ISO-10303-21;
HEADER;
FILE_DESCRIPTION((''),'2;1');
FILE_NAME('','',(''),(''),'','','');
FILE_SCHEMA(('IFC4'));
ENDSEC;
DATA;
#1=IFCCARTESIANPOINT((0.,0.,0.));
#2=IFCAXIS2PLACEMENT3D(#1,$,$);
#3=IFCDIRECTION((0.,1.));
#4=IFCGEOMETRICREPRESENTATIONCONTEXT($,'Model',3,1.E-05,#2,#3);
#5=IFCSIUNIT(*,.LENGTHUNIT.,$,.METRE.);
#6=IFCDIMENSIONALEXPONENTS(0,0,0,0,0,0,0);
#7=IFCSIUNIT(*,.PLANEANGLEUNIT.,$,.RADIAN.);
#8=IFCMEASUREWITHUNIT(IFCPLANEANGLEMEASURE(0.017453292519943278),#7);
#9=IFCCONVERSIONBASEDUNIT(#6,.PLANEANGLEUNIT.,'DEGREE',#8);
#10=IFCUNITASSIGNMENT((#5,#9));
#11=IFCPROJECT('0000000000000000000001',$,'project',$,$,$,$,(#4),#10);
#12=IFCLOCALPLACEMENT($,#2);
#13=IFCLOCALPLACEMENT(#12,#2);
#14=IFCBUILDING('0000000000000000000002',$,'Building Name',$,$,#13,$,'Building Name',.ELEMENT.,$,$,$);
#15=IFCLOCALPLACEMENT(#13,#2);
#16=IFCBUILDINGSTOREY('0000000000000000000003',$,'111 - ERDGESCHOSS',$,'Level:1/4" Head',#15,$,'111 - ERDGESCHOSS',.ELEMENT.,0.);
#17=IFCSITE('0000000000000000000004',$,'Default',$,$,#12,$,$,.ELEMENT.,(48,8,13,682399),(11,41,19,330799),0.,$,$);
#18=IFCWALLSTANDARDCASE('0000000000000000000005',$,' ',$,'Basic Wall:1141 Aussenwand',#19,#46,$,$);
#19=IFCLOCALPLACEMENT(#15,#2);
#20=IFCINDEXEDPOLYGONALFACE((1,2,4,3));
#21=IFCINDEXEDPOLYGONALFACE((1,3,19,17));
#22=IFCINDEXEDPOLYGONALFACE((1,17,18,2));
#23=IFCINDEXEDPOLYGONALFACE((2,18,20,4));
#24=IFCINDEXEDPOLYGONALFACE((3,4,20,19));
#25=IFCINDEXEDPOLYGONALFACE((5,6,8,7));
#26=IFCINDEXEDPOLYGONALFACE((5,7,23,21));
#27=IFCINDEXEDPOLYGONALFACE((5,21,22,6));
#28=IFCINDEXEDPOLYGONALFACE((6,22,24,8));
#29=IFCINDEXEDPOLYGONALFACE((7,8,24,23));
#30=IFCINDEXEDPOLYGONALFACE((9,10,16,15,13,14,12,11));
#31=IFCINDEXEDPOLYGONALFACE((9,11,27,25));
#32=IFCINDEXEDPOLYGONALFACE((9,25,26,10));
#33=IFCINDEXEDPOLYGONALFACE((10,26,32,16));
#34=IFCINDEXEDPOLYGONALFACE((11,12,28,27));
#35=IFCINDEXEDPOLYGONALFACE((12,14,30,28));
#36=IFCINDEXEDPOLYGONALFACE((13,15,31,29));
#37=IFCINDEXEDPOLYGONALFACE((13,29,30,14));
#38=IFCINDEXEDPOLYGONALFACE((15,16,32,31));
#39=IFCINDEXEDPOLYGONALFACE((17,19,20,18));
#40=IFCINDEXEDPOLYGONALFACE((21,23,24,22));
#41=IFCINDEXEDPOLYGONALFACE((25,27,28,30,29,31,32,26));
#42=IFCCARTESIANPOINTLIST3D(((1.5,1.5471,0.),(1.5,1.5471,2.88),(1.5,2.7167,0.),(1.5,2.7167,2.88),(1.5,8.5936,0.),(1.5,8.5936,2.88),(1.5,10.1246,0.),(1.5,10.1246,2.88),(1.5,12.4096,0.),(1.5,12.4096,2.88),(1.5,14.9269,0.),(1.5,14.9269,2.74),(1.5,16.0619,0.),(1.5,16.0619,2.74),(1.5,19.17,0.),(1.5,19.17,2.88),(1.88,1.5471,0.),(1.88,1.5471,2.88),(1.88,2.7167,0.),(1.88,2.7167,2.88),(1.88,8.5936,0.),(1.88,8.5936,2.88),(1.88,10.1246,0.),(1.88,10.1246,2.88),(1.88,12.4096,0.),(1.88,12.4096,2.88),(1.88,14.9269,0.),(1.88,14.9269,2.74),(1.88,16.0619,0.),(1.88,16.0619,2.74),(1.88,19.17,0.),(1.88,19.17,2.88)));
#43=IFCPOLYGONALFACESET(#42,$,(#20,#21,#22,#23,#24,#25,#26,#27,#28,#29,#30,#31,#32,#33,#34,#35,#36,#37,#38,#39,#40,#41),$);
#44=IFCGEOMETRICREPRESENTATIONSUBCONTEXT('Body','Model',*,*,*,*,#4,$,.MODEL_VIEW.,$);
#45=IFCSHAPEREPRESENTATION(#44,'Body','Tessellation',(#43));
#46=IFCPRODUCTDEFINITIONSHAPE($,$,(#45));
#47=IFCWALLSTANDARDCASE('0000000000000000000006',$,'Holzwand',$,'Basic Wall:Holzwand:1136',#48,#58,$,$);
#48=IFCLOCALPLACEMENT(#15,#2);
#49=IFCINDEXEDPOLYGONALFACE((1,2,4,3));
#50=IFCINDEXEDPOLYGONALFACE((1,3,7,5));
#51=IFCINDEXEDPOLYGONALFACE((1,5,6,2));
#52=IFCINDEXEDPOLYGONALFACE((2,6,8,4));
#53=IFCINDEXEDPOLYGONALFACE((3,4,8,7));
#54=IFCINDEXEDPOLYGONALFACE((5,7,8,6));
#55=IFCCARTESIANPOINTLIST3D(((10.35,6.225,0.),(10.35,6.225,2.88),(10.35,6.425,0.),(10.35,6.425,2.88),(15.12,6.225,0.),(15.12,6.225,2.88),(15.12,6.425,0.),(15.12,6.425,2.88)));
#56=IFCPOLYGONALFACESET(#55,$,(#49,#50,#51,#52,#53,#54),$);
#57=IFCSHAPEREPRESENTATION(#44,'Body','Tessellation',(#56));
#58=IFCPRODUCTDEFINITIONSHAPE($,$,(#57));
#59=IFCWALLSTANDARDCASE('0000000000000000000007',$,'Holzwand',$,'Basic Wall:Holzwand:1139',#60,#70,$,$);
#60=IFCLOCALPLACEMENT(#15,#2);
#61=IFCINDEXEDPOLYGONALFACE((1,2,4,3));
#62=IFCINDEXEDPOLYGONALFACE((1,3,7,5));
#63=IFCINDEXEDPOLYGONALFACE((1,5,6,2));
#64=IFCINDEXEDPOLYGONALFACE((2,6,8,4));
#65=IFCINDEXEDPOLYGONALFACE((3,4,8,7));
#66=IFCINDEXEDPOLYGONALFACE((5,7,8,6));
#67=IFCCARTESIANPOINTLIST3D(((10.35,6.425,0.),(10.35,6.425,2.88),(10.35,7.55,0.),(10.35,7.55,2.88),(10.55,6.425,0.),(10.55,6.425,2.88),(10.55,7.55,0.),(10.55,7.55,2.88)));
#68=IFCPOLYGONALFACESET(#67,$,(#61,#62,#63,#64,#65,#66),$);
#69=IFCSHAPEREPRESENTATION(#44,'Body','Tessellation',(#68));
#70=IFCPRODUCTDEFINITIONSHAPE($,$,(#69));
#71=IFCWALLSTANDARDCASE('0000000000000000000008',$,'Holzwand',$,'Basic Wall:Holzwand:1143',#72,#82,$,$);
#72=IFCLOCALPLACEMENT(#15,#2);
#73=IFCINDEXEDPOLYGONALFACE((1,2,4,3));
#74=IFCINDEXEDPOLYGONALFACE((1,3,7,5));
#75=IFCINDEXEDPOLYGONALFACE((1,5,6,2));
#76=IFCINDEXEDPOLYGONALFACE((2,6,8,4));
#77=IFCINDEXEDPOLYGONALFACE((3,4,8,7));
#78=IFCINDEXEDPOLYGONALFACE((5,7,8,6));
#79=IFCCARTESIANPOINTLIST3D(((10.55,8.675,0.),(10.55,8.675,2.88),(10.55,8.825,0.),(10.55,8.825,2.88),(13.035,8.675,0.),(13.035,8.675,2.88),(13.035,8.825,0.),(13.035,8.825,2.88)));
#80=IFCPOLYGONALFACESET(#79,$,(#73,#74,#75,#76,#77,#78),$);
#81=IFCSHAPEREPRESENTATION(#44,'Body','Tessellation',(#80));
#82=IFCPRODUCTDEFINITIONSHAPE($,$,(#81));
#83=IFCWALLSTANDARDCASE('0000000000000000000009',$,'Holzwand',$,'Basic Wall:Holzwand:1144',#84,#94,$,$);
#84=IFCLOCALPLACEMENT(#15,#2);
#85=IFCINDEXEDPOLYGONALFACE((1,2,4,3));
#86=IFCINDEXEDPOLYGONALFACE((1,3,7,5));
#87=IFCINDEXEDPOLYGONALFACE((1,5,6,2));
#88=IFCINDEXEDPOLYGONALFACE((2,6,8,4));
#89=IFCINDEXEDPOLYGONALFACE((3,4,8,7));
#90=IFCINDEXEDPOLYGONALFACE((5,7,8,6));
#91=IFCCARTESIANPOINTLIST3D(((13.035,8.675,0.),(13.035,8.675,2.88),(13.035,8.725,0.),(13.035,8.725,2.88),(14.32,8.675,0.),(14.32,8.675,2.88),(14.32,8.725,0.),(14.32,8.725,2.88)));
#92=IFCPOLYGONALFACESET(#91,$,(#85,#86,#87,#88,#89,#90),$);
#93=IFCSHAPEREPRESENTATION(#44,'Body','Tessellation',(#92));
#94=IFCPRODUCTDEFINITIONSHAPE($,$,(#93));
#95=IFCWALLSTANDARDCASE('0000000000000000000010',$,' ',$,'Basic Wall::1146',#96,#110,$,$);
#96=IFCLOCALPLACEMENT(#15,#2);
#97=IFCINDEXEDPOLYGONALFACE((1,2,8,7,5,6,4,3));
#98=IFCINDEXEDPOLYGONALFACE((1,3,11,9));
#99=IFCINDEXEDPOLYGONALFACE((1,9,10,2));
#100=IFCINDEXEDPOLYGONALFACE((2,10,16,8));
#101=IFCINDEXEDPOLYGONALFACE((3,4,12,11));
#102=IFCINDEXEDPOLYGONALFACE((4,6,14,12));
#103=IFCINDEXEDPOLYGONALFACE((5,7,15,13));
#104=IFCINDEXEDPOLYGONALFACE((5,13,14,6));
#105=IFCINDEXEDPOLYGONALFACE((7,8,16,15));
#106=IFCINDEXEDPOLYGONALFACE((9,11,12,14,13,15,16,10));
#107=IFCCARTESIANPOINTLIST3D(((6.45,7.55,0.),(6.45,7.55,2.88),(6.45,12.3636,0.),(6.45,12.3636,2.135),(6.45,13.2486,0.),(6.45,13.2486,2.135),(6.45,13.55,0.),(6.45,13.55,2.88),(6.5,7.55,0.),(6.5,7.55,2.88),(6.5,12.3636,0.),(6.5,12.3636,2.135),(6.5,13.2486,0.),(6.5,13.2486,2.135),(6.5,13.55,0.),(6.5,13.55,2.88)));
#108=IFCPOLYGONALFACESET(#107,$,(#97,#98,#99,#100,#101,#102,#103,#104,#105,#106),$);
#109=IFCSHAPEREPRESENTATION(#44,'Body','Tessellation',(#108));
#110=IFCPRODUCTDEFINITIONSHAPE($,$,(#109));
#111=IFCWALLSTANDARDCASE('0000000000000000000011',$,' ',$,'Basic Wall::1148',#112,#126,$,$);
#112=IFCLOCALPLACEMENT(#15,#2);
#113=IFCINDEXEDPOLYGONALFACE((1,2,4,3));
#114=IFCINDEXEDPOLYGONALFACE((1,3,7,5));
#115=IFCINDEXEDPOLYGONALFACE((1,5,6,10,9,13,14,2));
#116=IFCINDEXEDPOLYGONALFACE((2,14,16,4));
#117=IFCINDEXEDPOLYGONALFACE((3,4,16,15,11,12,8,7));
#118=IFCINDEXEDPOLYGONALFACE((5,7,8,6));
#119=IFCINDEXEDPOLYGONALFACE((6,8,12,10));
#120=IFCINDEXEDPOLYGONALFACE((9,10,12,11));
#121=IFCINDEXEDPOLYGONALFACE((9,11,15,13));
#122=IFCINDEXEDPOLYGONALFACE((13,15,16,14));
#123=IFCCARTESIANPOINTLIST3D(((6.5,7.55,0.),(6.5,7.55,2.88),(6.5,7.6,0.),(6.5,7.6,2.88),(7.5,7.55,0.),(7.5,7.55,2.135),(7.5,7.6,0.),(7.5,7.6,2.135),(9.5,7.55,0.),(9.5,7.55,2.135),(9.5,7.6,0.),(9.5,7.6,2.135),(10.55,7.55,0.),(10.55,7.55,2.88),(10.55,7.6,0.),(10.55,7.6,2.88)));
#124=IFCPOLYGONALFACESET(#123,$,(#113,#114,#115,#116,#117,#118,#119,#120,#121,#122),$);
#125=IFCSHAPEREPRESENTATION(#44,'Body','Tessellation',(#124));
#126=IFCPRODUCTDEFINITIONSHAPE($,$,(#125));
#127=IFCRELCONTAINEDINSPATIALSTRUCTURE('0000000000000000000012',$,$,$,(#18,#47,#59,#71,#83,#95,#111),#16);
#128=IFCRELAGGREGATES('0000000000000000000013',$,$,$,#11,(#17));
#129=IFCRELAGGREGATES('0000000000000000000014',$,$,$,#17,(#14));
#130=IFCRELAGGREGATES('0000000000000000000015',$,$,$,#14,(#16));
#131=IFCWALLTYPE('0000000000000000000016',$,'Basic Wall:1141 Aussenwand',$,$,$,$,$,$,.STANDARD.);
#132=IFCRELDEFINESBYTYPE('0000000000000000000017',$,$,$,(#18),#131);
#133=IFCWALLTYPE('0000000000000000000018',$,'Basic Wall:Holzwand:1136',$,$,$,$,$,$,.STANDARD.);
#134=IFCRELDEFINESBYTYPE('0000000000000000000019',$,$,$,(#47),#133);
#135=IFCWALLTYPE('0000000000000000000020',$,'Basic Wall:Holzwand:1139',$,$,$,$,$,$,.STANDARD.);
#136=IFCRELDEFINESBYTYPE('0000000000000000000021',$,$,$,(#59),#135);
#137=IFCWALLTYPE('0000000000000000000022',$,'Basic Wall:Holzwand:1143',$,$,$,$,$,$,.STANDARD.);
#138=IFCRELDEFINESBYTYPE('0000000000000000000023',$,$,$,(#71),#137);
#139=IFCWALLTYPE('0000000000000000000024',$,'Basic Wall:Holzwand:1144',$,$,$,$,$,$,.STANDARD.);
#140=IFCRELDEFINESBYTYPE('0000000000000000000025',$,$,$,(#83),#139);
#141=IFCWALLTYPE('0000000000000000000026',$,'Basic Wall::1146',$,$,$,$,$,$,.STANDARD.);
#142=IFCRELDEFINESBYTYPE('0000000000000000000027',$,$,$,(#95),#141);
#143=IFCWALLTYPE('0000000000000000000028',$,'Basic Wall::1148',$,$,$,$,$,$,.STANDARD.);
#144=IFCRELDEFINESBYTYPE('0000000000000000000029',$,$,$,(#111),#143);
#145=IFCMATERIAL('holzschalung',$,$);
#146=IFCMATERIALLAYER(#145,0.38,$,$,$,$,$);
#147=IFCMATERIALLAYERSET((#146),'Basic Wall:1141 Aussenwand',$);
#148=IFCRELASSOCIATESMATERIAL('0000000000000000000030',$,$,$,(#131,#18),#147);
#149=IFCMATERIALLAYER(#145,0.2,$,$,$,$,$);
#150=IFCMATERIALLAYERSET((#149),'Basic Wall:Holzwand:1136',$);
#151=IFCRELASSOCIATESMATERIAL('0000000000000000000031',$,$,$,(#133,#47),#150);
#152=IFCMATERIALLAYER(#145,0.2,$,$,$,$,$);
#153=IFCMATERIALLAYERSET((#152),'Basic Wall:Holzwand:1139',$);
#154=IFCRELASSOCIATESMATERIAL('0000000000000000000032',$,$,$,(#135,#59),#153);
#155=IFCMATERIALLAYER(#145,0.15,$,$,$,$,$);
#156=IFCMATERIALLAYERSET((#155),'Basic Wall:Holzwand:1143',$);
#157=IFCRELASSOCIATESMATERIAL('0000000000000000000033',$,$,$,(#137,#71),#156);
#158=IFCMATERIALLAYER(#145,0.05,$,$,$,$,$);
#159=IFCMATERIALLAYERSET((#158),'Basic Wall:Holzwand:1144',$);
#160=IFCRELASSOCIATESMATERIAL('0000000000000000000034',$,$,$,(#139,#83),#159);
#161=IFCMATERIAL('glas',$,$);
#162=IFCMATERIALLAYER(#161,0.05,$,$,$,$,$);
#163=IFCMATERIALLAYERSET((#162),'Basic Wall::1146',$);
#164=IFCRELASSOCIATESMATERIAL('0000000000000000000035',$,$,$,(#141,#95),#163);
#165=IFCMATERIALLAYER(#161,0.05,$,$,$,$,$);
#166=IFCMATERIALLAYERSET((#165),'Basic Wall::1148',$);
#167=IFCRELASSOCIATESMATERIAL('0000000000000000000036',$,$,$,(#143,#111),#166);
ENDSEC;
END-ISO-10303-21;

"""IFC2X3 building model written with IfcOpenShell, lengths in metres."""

from ifc_helpers import new_model, entity, si_unit, converted_unit, direction, frame, frame_2d, origin, place, context, subcontext, project, spatial, rectangle, extrude, material, layer, layer_set, layer_usage, type_object, element, save


model = new_model("IFC2X3")

# Units and contexts
model_context = context("Model", 3, precision=1e-05, world=origin(), true_north=direction((0.0, 1.0)))
body_context = subcontext(model_context, "Body", "Model", "MODEL_VIEW")
ifc_project = project(units=[si_unit("LENGTHUNIT", "METRE"), converted_unit("PLANEANGLEUNIT", "DEGREE", entity("IfcPlaneAngleMeasure", 0.017453292519943278), si_unit("PLANEANGLEUNIT", "RADIAN"), dimensions=[0, 0, 0, 0, 0, 0, 0])], contexts=[model_context])

# Site, building, storey
site_placement = place(None, origin())
site = spatial("IfcSite", under=ifc_project, at=site_placement, Name="Default", CompositionType="ELEMENT", RefLatitude=(48, 8, 13, 682399), RefLongitude=(11, 41, 19, 330799), RefElevation=0.0)
building_placement = place(site_placement, origin())
building = spatial("IfcBuilding", under=site, at=building_placement, Name="Building Name", LongName="Building Name", CompositionType="ELEMENT")
storey_placement = place(building_placement, origin())
storey = spatial("IfcBuildingStorey", under=building, at=storey_placement, Name="111 - ERDGESCHOSS", ObjectType="Level:1/4\" Head", LongName="111 - ERDGESCHOSS", CompositionType="ELEMENT", Elevation=0.0)

# Wall, openings
ifc_material_1 = material(Name="holzschalung")
ifc_layer_1 = layer(ifc_material_1, 0.38)
ifc_layer_set_1 = layer_set([ifc_layer_1], Name="Basic Wall:1141 Aussenwand")
ifc_layer_usage_1 = layer_usage(ifc_layer_set_1, "AXIS2", "NEGATIVE", 0.19)
wall_type_1 = type_object("IfcWallType", Name="Basic Wall:1141 Aussenwand", PredefinedType="STANDARD", material=ifc_layer_set_1)
wall_1_placement = place(storey_placement, frame((1.69, 1.5471, 0.0), z_axis=(0.0, 0.0, 1.0), x_axis=(0.0, 1.0, 0.0)))
wall_1 = element("IfcWallStandardCase", 1, at=wall_1_placement, inside=storey, type_object=wall_type_1, material=ifc_layer_usage_1, Name=" ", ObjectType="Basic Wall:1141 Aussenwand", context=body_context, shape_type="SweptSolid", body=[
    extrude(rectangle(XDim=17.6229, YDim=0.38, at=frame_2d((8.8114, 0.0), x_axis=(-1.0, 0.0))), origin(), (0.0, 0.0, 1.0), 2.88),
])
opening_1_placement = place(wall_1_placement, origin())
element("IfcOpeningElement", 2, at=opening_1_placement, cuts=wall_1, ObjectType="Opening", context=body_context, shape_type="SweptSolid", body=[
    extrude(rectangle(XDim=2.88, YDim=1.135, at=frame_2d((0.0, 0.0), x_axis=(0.0, 1.0))), frame((9.145, -0.19, 1.44), z_axis=(0.0, 1.0, 0.0), x_axis=(-1.0, 0.0, 0.0)), (0.0, 0.0, 1.0), 0.38),
])
opening_2_placement = place(wall_1_placement, origin())
element("IfcOpeningElement", 3, at=opening_2_placement, cuts=wall_1, ObjectType="Opening", context=body_context, shape_type="SweptSolid", body=[
    extrude(rectangle(XDim=2.88, YDim=1.135, at=frame_2d((0.0, 0.0), x_axis=(0.0, 1.0))), frame((6.4789, -0.19, 1.44), z_axis=(0.0, 1.0, 0.0), x_axis=(-1.0, 0.0, 0.0)), (0.0, 0.0, 1.0), 0.38),
])
opening_3_placement = place(wall_1_placement, origin())
element("IfcOpeningElement", 4, at=opening_3_placement, cuts=wall_1, ObjectType="Opening", context=body_context, shape_type="SweptSolid", body=[
    extrude(rectangle(XDim=2.88, YDim=1.135, at=frame_2d((0.0, 0.0), x_axis=(0.0, 1.0))), frame((1.7371, -0.19, 1.44), z_axis=(0.0, 1.0, 0.0), x_axis=(-1.0, 0.0, 0.0)), (0.0, 0.0, 1.0), 0.38),
])
opening_4_placement = place(wall_1_placement, origin())
element("IfcOpeningElement", 5, at=opening_4_placement, cuts=wall_1, ObjectType="Opening", context=body_context, shape_type="SweptSolid", body=[
    extrude(rectangle(XDim=2.88, YDim=1.15, at=frame_2d((0.0, 0.0), x_axis=(0.0, 1.0))), frame((10.2875, -0.19, 1.44), z_axis=(0.0, 1.0, 0.0), x_axis=(-1.0, 0.0, 0.0)), (0.0, 0.0, 1.0), 0.38),
])
opening_5_placement = place(wall_1_placement, origin())
element("IfcOpeningElement", 6, at=opening_5_placement, cuts=wall_1, ObjectType="Opening", context=body_context, shape_type="SweptSolid", body=[
    extrude(rectangle(XDim=2.74, YDim=1.135, at=frame_2d((0.0, 0.0), x_axis=(0.0, 1.0))), frame((13.9473, -0.19, 1.37), z_axis=(0.0, 1.0, 0.0), x_axis=(-1.0, 0.0, 0.0)), (0.0, 0.0, 1.0), 0.38),
])
opening_6_placement = place(wall_1_placement, origin())
element("IfcOpeningElement", 7, at=opening_6_placement, cuts=wall_1, ObjectType="Opening", context=body_context, shape_type="SweptSolid", body=[
    extrude(rectangle(XDim=2.88, YDim=3.608, at=frame_2d((0.0, 0.0), x_axis=(0.0, 1.0))), frame((4.1074, -0.19, 1.44), z_axis=(0.0, 1.0, 0.0), x_axis=(-1.0, 0.0, 0.0)), (0.0, 0.0, 1.0), 0.38),
])

# Walls
ifc_layer_2 = layer(ifc_material_1, 0.2)
ifc_layer_set_2 = layer_set([ifc_layer_2], Name="Basic Wall:Holzwand:1136")
ifc_layer_usage_2 = layer_usage(ifc_layer_set_2, "AXIS2", "NEGATIVE", 0.1)
wall_type_2 = type_object("IfcWallType", Name="Basic Wall:Holzwand:1136", PredefinedType="STANDARD", material=ifc_layer_set_2)
wall_2_placement = place(storey_placement, frame((15.12, 6.325, 0.0), z_axis=(0.0, 0.0, 1.0), x_axis=(-1.0, 0.0, 0.0)))
element("IfcWallStandardCase", 8, at=wall_2_placement, inside=storey, type_object=wall_type_2, material=ifc_layer_usage_2, Name="Holzwand", ObjectType="Basic Wall:Holzwand:1136", context=body_context, shape_type="SweptSolid", body=[
    extrude(rectangle(XDim=4.77, YDim=0.2, at=frame_2d((2.385, 0.0), x_axis=(-1.0, 0.0))), origin(), (0.0, 0.0, 1.0), 2.88),
])
ifc_layer_3 = layer(ifc_material_1, 0.2)
ifc_layer_set_3 = layer_set([ifc_layer_3], Name="Basic Wall:Holzwand:1139")
ifc_layer_usage_3 = layer_usage(ifc_layer_set_3, "AXIS2", "NEGATIVE", 0.1)
wall_type_3 = type_object("IfcWallType", Name="Basic Wall:Holzwand:1139", PredefinedType="STANDARD", material=ifc_layer_set_3)
wall_3_placement = place(storey_placement, frame((10.45, 7.55, 0.0), z_axis=(0.0, 0.0, 1.0), x_axis=(0.0, -1.0, 0.0)))
element("IfcWallStandardCase", 9, at=wall_3_placement, inside=storey, type_object=wall_type_3, material=ifc_layer_usage_3, Name="Holzwand", ObjectType="Basic Wall:Holzwand:1139", context=body_context, shape_type="SweptSolid", body=[
    extrude(rectangle(XDim=1.125, YDim=0.2, at=frame_2d((0.5625, 0.0), x_axis=(-1.0, 0.0))), origin(), (0.0, 0.0, 1.0), 2.88),
])
ifc_layer_4 = layer(ifc_material_1, 0.15)
ifc_layer_set_4 = layer_set([ifc_layer_4], Name="Basic Wall:Holzwand:1143")
ifc_layer_usage_4 = layer_usage(ifc_layer_set_4, "AXIS2", "NEGATIVE", 0.075)
wall_type_4 = type_object("IfcWallType", Name="Basic Wall:Holzwand:1143", PredefinedType="STANDARD", material=ifc_layer_set_4)
wall_4_placement = place(storey_placement, frame((13.035, 8.75, 0.0), z_axis=(0.0, 0.0, 1.0), x_axis=(-1.0, 0.0, 0.0)))
element("IfcWallStandardCase", 10, at=wall_4_placement, inside=storey, type_object=wall_type_4, material=ifc_layer_usage_4, Name="Holzwand", ObjectType="Basic Wall:Holzwand:1143", context=body_context, shape_type="SweptSolid", body=[
    extrude(rectangle(XDim=2.485, YDim=0.15, at=frame_2d((1.2425, 0.0), x_axis=(-1.0, 0.0))), origin(), (0.0, 0.0, 1.0), 2.88),
])
ifc_layer_5 = layer(ifc_material_1, 0.05)
ifc_layer_set_5 = layer_set([ifc_layer_5], Name="Basic Wall:Holzwand:1144")
ifc_layer_usage_5 = layer_usage(ifc_layer_set_5, "AXIS2", "NEGATIVE", 0.025)
wall_type_5 = type_object("IfcWallType", Name="Basic Wall:Holzwand:1144", PredefinedType="STANDARD", material=ifc_layer_set_5)
wall_5_placement = place(storey_placement, frame((13.035, 8.7, 0.0)))
element("IfcWallStandardCase", 11, at=wall_5_placement, inside=storey, type_object=wall_type_5, material=ifc_layer_usage_5, Name="Holzwand", ObjectType="Basic Wall:Holzwand:1144", context=body_context, shape_type="SweptSolid", body=[
    extrude(rectangle(XDim=1.285, YDim=0.05, at=frame_2d((0.6425, 0.0), x_axis=(-1.0, 0.0))), origin(), (0.0, 0.0, 1.0), 2.88),
])

# Walls, openings
ifc_material_2 = material(Name="glas")
ifc_layer_6 = layer(ifc_material_2, 0.05)
ifc_layer_set_6 = layer_set([ifc_layer_6], Name="Basic Wall::1146")
ifc_layer_usage_6 = layer_usage(ifc_layer_set_6, "AXIS2", "NEGATIVE", 0.025)
wall_type_6 = type_object("IfcWallType", Name="Basic Wall::1146", PredefinedType="STANDARD", material=ifc_layer_set_6)
wall_6_placement = place(storey_placement, frame((6.475, 7.55, 0.0), z_axis=(0.0, 0.0, 1.0), x_axis=(0.0, 1.0, 0.0)))
wall_6 = element("IfcWallStandardCase", 12, at=wall_6_placement, inside=storey, type_object=wall_type_6, material=ifc_layer_usage_6, Name=" ", ObjectType="Basic Wall::1146", context=body_context, shape_type="SweptSolid", body=[
    extrude(rectangle(XDim=6.0, YDim=0.05, at=frame_2d((3.0, 0.0), x_axis=(-1.0, 0.0))), origin(), (0.0, 0.0, 1.0), 2.88),
])
opening_7_placement = place(wall_6_placement, frame((-7.55, 6.475, 0.0), z_axis=(0.0, 0.0, 1.0), x_axis=(0.0, -1.0, 0.0)))
element("IfcOpeningElement", 13, at=opening_7_placement, cuts=wall_6, ObjectType="Opening", context=body_context, shape_type="SweptSolid", body=[
    extrude(rectangle(XDim=2.135, YDim=0.885, at=frame_2d((0.0, 0.0), x_axis=(0.0, 1.0))), frame((6.5005, 12.8061, 1.0675), z_axis=(-1.0, 0.0, 0.0), x_axis=(0.0, -1.0, 0.0)), (0.0, 0.0, 1.0), 0.051),
])
ifc_layer_7 = layer(ifc_material_2, 0.05)
ifc_layer_set_7 = layer_set([ifc_layer_7], Name="Basic Wall::1148")
ifc_layer_usage_7 = layer_usage(ifc_layer_set_7, "AXIS2", "NEGATIVE", 0.025)
wall_type_7 = type_object("IfcWallType", Name="Basic Wall::1148", PredefinedType="STANDARD", material=ifc_layer_set_7)
wall_7_placement = place(storey_placement, frame((10.55, 7.575, 0.0), z_axis=(0.0, 0.0, 1.0), x_axis=(-1.0, 0.0, 0.0)))
wall_7 = element("IfcWallStandardCase", 14, at=wall_7_placement, inside=storey, type_object=wall_type_7, material=ifc_layer_usage_7, Name=" ", ObjectType="Basic Wall::1148", context=body_context, shape_type="SweptSolid", body=[
    extrude(rectangle(XDim=4.05, YDim=0.05, at=frame_2d((2.025, 0.0), x_axis=(1.0, 0.0))), origin(), (0.0, 0.0, 1.0), 2.88),
])
opening_8_placement = place(wall_7_placement, frame((10.55, 7.575, 0.0), z_axis=(0.0, 0.0, 1.0), x_axis=(-1.0, 0.0, 0.0)))
element("IfcOpeningElement", 15, at=opening_8_placement, cuts=wall_7, ObjectType="Opening", context=body_context, shape_type="SweptSolid", body=[
    extrude(rectangle(XDim=2.135, YDim=2.0, at=frame_2d((0.0, 0.0), x_axis=(0.0, 1.0))), frame((8.5, 7.6005, 1.0675), z_axis=(0.0, -1.0, 0.0), x_axis=(1.0, 0.0, 0.0)), (0.0, 0.0, 1.0), 0.051),
])

save(model, "model.ifc")
